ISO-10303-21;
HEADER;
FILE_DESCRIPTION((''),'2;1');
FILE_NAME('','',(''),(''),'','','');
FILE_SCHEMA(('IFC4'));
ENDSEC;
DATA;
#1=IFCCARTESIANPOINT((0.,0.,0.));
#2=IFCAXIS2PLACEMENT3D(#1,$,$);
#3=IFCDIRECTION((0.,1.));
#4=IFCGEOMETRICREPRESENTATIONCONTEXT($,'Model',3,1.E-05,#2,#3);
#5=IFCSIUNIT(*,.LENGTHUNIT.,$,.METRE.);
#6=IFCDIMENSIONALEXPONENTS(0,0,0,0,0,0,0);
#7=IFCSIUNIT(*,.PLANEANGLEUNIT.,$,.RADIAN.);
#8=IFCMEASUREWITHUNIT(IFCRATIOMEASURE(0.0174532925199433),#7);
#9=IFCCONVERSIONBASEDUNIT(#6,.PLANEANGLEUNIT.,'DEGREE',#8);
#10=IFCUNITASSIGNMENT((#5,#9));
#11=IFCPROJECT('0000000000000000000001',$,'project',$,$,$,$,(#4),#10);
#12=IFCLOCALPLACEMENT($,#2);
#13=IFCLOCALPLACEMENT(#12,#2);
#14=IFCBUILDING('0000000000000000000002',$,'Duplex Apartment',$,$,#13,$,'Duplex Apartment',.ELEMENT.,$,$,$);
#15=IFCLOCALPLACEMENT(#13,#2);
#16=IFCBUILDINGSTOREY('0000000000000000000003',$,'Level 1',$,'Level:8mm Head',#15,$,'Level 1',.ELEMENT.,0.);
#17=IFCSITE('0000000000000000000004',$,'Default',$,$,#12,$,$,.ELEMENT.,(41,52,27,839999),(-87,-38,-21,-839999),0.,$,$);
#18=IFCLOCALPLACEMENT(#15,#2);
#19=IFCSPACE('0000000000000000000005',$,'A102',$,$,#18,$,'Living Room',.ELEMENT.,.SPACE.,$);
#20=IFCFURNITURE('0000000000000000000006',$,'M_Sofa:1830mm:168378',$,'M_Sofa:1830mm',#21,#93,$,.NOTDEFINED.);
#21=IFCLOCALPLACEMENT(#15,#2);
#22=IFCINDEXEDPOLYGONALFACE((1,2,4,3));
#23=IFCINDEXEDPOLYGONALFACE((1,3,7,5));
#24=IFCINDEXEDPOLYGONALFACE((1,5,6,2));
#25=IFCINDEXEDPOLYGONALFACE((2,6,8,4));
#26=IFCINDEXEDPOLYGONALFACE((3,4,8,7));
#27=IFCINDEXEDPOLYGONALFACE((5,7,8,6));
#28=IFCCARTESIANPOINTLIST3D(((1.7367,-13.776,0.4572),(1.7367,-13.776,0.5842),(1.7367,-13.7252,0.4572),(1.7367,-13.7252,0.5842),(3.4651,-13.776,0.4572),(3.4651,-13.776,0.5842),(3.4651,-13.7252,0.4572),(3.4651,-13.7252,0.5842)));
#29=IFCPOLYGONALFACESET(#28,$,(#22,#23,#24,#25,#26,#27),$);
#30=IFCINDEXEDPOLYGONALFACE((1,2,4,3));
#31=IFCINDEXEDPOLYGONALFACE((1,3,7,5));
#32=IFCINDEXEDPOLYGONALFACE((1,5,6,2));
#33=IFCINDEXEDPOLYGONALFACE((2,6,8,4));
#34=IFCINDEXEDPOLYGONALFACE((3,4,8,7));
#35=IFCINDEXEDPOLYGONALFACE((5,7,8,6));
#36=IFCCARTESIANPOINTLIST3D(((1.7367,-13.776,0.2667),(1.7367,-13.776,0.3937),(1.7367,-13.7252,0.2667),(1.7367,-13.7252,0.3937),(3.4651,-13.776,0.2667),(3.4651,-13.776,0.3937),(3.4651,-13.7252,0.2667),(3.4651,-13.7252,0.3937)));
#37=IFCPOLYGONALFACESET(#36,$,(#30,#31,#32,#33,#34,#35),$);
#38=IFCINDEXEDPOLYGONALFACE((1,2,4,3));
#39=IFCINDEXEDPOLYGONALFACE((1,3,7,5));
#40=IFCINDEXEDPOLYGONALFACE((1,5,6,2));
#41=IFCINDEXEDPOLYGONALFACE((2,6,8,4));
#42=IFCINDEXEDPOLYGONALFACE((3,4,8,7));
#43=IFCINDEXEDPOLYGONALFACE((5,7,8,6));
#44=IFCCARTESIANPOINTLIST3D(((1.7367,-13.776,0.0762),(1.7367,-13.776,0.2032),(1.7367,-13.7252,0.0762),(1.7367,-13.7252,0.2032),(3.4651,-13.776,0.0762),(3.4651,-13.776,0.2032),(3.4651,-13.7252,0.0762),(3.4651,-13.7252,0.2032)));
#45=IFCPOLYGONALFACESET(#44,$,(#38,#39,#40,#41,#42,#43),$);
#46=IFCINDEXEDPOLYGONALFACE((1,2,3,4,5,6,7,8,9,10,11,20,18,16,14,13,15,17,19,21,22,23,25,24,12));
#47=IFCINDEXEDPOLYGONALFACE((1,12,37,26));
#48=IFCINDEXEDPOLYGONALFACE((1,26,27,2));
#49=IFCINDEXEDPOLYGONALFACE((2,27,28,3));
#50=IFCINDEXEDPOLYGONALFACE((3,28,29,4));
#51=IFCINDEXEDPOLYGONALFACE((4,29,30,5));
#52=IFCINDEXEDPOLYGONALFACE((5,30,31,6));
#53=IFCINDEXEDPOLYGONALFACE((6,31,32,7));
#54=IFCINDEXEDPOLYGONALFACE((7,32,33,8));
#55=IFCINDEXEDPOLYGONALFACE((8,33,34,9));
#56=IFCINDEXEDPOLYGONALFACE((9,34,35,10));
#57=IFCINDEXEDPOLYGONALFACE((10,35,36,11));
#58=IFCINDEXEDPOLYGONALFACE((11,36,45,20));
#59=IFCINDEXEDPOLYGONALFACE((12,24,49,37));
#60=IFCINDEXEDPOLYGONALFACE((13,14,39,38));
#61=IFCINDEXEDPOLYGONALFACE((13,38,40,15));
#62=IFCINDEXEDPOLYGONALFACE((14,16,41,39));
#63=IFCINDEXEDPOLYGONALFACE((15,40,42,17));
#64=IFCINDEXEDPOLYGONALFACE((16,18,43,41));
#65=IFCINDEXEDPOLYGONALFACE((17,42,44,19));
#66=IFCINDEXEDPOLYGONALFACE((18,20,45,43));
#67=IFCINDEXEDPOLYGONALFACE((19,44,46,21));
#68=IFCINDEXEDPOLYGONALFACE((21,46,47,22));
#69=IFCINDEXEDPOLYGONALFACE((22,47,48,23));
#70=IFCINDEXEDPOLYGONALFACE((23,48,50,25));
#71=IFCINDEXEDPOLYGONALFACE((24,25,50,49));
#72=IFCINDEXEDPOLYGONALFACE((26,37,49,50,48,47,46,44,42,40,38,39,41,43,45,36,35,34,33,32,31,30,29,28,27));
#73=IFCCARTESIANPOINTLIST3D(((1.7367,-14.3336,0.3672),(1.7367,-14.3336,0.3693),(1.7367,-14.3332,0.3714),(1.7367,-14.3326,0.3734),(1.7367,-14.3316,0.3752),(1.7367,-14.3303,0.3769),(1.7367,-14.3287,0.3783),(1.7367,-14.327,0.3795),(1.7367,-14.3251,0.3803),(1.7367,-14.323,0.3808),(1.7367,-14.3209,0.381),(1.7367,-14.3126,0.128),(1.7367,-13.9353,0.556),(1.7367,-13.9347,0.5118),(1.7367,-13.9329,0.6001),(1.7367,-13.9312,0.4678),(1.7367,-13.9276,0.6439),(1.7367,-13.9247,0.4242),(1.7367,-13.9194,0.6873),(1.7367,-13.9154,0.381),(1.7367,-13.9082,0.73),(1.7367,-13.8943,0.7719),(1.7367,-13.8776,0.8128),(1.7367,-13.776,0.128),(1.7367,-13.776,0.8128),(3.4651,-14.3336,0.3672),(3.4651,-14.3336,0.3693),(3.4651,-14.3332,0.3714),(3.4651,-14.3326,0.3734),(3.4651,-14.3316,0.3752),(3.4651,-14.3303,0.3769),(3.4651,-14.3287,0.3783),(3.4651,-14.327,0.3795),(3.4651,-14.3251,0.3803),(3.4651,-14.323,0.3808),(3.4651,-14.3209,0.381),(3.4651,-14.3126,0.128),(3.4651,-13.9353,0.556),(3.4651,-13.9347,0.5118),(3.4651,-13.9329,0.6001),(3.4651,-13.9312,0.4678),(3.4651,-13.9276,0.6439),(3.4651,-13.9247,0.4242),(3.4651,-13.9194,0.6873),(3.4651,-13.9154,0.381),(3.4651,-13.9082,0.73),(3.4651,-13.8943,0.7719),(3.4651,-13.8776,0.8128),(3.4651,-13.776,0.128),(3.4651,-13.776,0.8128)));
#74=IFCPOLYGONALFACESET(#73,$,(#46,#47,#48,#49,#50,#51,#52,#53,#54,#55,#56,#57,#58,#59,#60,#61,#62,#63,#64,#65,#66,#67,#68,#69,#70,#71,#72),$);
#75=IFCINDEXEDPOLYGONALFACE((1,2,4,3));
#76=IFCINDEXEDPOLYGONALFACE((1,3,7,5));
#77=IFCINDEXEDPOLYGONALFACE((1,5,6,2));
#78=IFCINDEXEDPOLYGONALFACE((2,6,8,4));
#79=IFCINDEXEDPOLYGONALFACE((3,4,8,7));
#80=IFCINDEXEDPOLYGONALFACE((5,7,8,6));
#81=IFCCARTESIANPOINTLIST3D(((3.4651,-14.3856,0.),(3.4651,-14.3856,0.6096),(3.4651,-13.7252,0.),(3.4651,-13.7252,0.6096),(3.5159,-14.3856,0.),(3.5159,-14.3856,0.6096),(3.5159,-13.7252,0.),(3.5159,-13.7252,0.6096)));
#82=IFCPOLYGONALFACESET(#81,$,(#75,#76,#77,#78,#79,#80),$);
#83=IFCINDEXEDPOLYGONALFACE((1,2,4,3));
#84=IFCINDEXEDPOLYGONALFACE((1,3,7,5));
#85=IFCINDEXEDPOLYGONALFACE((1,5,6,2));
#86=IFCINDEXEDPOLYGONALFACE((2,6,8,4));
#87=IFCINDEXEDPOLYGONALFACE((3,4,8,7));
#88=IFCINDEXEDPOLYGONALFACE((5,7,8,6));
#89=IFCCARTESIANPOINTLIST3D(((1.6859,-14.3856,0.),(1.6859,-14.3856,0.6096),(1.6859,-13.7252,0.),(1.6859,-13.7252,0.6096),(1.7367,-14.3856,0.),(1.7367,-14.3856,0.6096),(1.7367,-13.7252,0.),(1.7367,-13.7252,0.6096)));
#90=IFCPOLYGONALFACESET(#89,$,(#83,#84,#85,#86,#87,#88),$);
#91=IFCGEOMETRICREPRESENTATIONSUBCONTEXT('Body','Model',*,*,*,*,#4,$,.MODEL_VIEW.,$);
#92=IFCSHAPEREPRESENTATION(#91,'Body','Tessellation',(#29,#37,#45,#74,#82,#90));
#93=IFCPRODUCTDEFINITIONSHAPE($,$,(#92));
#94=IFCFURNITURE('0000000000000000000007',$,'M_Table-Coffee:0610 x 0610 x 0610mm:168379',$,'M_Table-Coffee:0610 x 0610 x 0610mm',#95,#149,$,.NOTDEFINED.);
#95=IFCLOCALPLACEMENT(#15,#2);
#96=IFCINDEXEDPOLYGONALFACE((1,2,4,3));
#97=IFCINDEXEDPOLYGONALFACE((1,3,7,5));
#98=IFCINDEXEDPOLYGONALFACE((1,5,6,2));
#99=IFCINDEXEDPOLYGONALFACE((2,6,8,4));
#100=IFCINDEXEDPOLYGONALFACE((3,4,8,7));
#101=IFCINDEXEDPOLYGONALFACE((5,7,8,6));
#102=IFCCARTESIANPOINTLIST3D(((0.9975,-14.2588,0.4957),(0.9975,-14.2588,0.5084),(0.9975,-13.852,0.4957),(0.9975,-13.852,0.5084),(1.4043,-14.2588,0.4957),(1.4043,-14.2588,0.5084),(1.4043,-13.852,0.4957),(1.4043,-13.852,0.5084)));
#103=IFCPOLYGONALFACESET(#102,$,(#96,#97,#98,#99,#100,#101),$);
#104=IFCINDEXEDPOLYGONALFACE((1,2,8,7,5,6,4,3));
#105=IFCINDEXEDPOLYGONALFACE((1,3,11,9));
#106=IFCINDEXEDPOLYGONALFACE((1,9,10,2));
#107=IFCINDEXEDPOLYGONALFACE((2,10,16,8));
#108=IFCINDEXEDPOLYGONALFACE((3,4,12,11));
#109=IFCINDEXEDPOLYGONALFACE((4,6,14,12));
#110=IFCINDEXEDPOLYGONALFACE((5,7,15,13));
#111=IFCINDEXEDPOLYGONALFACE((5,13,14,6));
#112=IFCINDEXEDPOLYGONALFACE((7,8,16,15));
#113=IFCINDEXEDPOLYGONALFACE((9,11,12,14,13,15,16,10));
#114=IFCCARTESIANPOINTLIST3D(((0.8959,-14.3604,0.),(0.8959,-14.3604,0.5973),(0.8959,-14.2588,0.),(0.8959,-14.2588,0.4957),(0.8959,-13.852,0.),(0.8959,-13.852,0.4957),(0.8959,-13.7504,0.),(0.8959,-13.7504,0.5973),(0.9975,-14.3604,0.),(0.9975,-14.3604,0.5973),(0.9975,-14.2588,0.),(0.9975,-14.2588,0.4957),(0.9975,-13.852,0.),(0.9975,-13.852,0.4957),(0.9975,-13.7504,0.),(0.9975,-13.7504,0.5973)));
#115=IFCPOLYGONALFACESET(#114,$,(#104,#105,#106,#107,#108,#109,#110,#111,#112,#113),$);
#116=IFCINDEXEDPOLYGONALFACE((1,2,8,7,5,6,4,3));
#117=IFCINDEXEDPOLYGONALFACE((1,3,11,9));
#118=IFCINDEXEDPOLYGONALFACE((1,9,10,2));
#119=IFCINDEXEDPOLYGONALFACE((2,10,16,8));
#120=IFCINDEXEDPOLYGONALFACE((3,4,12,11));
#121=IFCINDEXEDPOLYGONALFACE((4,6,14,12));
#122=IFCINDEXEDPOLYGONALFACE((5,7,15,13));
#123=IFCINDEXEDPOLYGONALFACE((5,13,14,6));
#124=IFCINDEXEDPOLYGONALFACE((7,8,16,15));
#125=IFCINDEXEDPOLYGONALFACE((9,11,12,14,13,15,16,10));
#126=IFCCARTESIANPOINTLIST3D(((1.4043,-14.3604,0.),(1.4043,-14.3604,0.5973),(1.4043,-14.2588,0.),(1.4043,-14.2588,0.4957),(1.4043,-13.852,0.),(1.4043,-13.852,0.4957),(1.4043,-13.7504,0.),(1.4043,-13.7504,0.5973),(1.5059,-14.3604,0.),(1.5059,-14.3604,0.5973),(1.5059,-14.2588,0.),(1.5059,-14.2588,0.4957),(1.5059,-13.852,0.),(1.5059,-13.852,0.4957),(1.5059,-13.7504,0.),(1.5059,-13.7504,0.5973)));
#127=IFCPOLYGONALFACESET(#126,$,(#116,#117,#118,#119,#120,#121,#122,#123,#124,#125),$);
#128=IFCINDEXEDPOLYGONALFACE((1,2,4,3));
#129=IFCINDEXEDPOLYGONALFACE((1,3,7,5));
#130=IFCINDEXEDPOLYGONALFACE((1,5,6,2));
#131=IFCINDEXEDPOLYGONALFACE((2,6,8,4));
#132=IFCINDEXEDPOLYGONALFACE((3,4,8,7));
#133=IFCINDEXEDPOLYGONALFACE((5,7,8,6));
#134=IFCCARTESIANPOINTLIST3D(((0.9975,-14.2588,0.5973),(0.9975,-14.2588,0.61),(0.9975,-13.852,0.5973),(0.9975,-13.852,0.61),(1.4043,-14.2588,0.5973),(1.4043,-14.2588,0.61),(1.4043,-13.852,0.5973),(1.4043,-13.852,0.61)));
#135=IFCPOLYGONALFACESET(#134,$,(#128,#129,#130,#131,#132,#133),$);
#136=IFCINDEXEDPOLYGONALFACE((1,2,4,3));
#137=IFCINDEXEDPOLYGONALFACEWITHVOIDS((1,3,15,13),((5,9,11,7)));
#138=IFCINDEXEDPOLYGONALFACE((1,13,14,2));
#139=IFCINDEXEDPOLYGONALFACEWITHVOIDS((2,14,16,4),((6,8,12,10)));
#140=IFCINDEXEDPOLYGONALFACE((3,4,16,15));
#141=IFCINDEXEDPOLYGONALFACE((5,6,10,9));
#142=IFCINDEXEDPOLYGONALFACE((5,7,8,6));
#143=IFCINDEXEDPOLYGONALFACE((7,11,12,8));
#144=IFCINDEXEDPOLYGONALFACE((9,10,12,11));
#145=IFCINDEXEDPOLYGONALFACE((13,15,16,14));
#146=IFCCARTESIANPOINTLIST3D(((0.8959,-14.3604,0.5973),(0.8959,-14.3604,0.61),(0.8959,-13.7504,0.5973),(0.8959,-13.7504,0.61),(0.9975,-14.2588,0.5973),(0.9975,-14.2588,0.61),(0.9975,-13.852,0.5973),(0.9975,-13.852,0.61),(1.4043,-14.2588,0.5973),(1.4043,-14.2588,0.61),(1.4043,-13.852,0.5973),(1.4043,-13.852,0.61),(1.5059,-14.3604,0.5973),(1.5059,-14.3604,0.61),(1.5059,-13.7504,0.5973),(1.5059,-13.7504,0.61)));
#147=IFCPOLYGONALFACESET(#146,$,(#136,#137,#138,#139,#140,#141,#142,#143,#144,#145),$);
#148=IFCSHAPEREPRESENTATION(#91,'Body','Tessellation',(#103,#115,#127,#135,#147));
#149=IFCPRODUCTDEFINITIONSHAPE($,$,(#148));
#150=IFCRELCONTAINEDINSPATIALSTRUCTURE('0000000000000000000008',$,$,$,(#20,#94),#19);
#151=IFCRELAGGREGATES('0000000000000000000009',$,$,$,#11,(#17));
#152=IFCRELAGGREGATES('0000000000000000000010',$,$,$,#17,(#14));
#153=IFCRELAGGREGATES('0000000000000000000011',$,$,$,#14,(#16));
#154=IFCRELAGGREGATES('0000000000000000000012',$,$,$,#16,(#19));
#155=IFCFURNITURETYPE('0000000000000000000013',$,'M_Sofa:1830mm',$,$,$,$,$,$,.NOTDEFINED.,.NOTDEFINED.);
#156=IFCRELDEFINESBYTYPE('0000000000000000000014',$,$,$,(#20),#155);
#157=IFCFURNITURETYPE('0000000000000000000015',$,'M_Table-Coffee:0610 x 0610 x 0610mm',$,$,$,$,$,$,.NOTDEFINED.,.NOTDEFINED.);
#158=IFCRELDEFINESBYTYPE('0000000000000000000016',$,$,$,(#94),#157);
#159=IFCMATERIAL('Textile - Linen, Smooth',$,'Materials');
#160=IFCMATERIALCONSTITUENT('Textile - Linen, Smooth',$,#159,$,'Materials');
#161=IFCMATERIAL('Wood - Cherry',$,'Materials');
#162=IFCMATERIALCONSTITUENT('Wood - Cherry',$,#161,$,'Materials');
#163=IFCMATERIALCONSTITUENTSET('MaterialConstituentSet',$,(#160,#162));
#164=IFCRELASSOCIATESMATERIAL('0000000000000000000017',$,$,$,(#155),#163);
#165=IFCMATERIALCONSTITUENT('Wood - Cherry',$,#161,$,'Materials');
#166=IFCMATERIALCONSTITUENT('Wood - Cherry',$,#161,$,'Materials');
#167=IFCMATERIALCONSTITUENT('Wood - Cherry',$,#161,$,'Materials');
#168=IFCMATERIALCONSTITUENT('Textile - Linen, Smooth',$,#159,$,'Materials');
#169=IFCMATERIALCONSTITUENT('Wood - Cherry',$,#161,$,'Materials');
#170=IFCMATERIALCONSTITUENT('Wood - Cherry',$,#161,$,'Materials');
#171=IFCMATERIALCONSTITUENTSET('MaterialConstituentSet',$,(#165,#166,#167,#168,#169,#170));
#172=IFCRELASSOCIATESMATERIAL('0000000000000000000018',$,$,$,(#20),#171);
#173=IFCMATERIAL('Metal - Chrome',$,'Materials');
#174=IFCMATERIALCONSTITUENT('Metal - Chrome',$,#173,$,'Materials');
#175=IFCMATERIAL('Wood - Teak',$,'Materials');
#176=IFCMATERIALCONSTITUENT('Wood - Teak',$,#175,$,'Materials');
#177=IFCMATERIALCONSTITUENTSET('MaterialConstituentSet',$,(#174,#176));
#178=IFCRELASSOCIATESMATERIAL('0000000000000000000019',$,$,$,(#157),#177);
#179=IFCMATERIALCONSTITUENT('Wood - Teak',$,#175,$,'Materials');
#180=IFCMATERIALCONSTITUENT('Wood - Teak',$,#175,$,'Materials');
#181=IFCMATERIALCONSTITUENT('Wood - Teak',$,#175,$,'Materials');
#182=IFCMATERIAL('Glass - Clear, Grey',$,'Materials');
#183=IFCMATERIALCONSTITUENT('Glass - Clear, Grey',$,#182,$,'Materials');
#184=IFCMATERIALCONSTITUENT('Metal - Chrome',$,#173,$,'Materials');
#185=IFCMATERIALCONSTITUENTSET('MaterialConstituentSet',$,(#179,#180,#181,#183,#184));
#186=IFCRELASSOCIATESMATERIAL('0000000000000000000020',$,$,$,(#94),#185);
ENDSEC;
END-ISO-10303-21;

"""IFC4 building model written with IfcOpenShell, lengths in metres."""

from ifc_helpers import new_model, entity, si_unit, converted_unit, direction, frame, origin, place, context, subcontext, project, spatial, indexed_curve, outline, extrude, source, transform, mapped, material, constituent, constituent_set, type_object, type_shapes, element, save


model = new_model("IFC4")

# Units and contexts
model_context = context("Model", 3, precision=1e-05, world=origin(), true_north=direction((0.0, 1.0)))
body_context = subcontext(model_context, "Body", "Model", "MODEL_VIEW")
ifc_project = project(units=[si_unit("LENGTHUNIT", "METRE"), converted_unit("PLANEANGLEUNIT", "DEGREE", entity("IfcRatioMeasure", 0.0174532925199433), si_unit("PLANEANGLEUNIT", "RADIAN"), dimensions=[0, 0, 0, 0, 0, 0, 0])], contexts=[model_context])

# Site, building, storey
site_placement = place(None, origin())
site = spatial("IfcSite", under=ifc_project, at=site_placement, Name="Default", CompositionType="ELEMENT", RefLatitude=(41, 52, 27, 839999), RefLongitude=(-87, -38, -21, -839999), RefElevation=0.0)
building_placement = place(site_placement, origin())
building = spatial("IfcBuilding", under=site, at=building_placement, Name="Duplex Apartment", LongName="Duplex Apartment", CompositionType="ELEMENT")
storey_placement = place(building_placement, origin())
storey = spatial("IfcBuildingStorey", under=building, at=storey_placement, Name="Level 1", ObjectType="Level:8mm Head", LongName="Level 1", CompositionType="ELEMENT", Elevation=0.0)

# Shared definitions
space_1_placement = place(storey_placement, origin())
space_1 = spatial("IfcSpace", under=storey, at=space_1_placement, Name="A102", LongName="Living Room", CompositionType="ELEMENT", PredefinedType="SPACE")

# Furniture
ifc_material_1 = material(Name="Wood - Cherry", Category="Materials")
ifc_material_2 = material(Name="Textile - Linen, Smooth", Category="Materials")
ifc_constituent_1 = constituent(ifc_material_2, Name="Textile - Linen, Smooth", Category="Materials")
ifc_constituent_2 = constituent(ifc_material_1, Name="Wood - Cherry", Category="Materials")
ifc_constituent_set_1 = constituent_set(constituents=[ifc_constituent_1, ifc_constituent_2], Name="MaterialConstituentSet")
furniture_type_1 = type_object("IfcFurnitureType", Name="M_Sofa:1830mm", AssemblyPlace="NOTDEFINED", PredefinedType="NOTDEFINED", material=ifc_constituent_set_1)
shared_shape_1 = source(origin(), body_context, "Body", "SweptSolid", [
    extrude(outline(indexed_curve([(-0.8642, -0.0254), (0.8642, -0.0254), (0.8642, 0.0254), (-0.8642, 0.0254), (-0.8642, -0.0254)], self_intersect=False)), frame((0.0704, 0.451, 0.4572)), (0.0, 0.0, 1.0), 0.127),
    extrude(outline(indexed_curve([(-0.8642, -0.0254), (0.8642, -0.0254), (0.8642, 0.0254), (-0.8642, 0.0254), (-0.8642, -0.0254)], self_intersect=False)), frame((0.0704, 0.451, 0.2667)), (0.0, 0.0, 1.0), 0.127),
    extrude(outline(indexed_curve([(-0.8642, -0.0254), (0.8642, -0.0254), (0.8642, 0.0254), (-0.8642, 0.0254), (-0.8642, -0.0254)], self_intersect=False)), frame((0.0704, 0.451, 0.0762)), (0.0, 0.0, 1.0), 0.127),
    extrude(outline(indexed_curve([(-0.1292, 0.0491), (0.2763, 0.0491), (0.2784, 0.0493), (0.2805, 0.0498), (0.2824, 0.0506), (0.2842, 0.0518), (0.2857, 0.0532), (0.287, 0.0549), (0.288, 0.0567), (0.2887, 0.0587), (0.289, 0.0608), (0.289, 0.0629), (0.2681, 0.3021), (-0.2686, 0.3021), (-0.2686, -0.3827), (-0.167, -0.3827), (-0.1503, -0.3418), (-0.1363, -0.2999), (-0.1252, -0.2572), (-0.117, -0.2138), (-0.1117, -0.17), (-0.1093, -0.1259), (-0.1099, -0.0817), (-0.1134, -0.0377), (-0.1199, 0.006), (-0.1292, 0.0491)], self_intersect=False)), frame((-0.7938, 0.157, 0.4301), z_axis=(1.0, 0.0, 0.0), x_axis=(0.0, -1.0, 0.0)), (0.0, 0.0, 1.0), 1.7284),
    extrude(outline(indexed_curve([(-0.0254, -0.3302), (0.0254, -0.3302), (0.0254, 0.3302), (-0.0254, 0.3302), (-0.0254, -0.3302)], self_intersect=False)), frame((0.96, 0.1462, 0.0), z_axis=(0.0, 0.0, 1.0), x_axis=(-1.0, 0.0, 0.0)), (0.0, 0.0, 1.0), 0.6096),
    extrude(outline(indexed_curve([(-0.0254, -0.3302), (0.0254, -0.3302), (0.0254, 0.3302), (-0.0254, 0.3302), (-0.0254, -0.3302)], self_intersect=False)), frame((-0.8192, 0.1462, 0.0), z_axis=(0.0, 0.0, 1.0), x_axis=(-1.0, 0.0, 0.0)), (0.0, 0.0, 1.0), 0.6096),
])
type_shapes(furniture_type_1, [shared_shape_1])
ifc_constituent_3 = constituent(ifc_material_1, Name="Wood - Cherry", Category="Materials")
ifc_constituent_4 = constituent(ifc_material_1, Name="Wood - Cherry", Category="Materials")
ifc_constituent_5 = constituent(ifc_material_1, Name="Wood - Cherry", Category="Materials")
ifc_constituent_6 = constituent(ifc_material_2, Name="Textile - Linen, Smooth", Category="Materials")
ifc_constituent_7 = constituent(ifc_material_1, Name="Wood - Cherry", Category="Materials")
ifc_constituent_8 = constituent(ifc_material_1, Name="Wood - Cherry", Category="Materials")
ifc_constituent_set_2 = constituent_set(constituents=[ifc_constituent_3, ifc_constituent_4, ifc_constituent_5, ifc_constituent_6, ifc_constituent_7, ifc_constituent_8], Name="MaterialConstituentSet")
furniture_1_placement = place(space_1_placement, frame((2.5305, -14.2015, 0.0)))
element("IfcFurniture", 1, at=furniture_1_placement, inside=space_1, type_object=furniture_type_1, material=ifc_constituent_set_2, Name="M_Sofa:1830mm:168378", ObjectType="M_Sofa:1830mm", PredefinedType="NOTDEFINED", context=body_context, shape_type="MappedRepresentation", body=[
    mapped(shared_shape_1, transform((0.0, 0.0, 0.0), scale=1.0)),
])
ifc_material_3 = material(Name="Wood - Teak", Category="Materials")
ifc_constituent_9 = constituent(ifc_material_3, Name="Wood - Teak", Category="Materials")
ifc_constituent_10 = constituent(ifc_material_3, Name="Wood - Teak", Category="Materials")
ifc_constituent_11 = constituent(ifc_material_3, Name="Wood - Teak", Category="Materials")
ifc_material_4 = material(Name="Glass - Clear, Grey", Category="Materials")
ifc_constituent_12 = constituent(ifc_material_4, Name="Glass - Clear, Grey", Category="Materials")
ifc_material_5 = material(Name="Metal - Chrome", Category="Materials")
ifc_constituent_13 = constituent(ifc_material_5, Name="Metal - Chrome", Category="Materials")
ifc_constituent_set_3 = constituent_set(constituents=[ifc_constituent_9, ifc_constituent_10, ifc_constituent_11, ifc_constituent_12, ifc_constituent_13], Name="MaterialConstituentSet")
ifc_constituent_14 = constituent(ifc_material_5, Name="Metal - Chrome", Category="Materials")
ifc_constituent_15 = constituent(ifc_material_3, Name="Wood - Teak", Category="Materials")
ifc_constituent_set_4 = constituent_set(constituents=[ifc_constituent_14, ifc_constituent_15], Name="MaterialConstituentSet")
furniture_type_2 = type_object("IfcFurnitureType", Name="M_Table-Coffee:0610 x 0610 x 0610mm", AssemblyPlace="NOTDEFINED", PredefinedType="NOTDEFINED", material=ifc_constituent_set_4)
shared_shape_2 = source(origin(), body_context, "Body", "SweptSolid", [
    extrude(outline(indexed_curve([(-0.2034, -0.2034), (0.2034, -0.2034), (0.2034, 0.2034), (-0.2034, 0.2034), (-0.2034, -0.2034)], self_intersect=False)), frame((0.0183, 0.0952, 0.4957), z_axis=(0.0, 0.0, 1.0), x_axis=(-1.0, 0.0, 0.0)), (0.0, 0.0, 1.0), 0.0127),
    extrude(outline(indexed_curve([(-0.2732, -0.305), (0.324, -0.305), (0.324, 0.305), (-0.2732, 0.305), (-0.2732, 0.2034), (0.2225, 0.2034), (0.2225, -0.2034), (-0.2732, -0.2034), (-0.2732, -0.305)], self_intersect=False)), frame((0.2217, 0.0952, 0.2732), z_axis=(1.0, 0.0, 0.0), x_axis=(0.0, 0.0, 1.0)), (0.0, 0.0, 1.0), 0.1016),
    extrude(outline(indexed_curve([(-0.305, -0.3241), (0.305, -0.3241), (0.305, 0.2733), (0.2034, 0.2733), (0.2034, -0.2224), (-0.2034, -0.2224), (-0.2034, 0.2733), (-0.305, 0.2733), (-0.305, -0.3241)], self_intersect=False)), frame((-0.2867, 0.0952, 0.2733), z_axis=(1.0, 0.0, 0.0), x_axis=(0.0, -1.0, 0.0)), (0.0, 0.0, 1.0), 0.1016),
    extrude(outline(indexed_curve([(-0.2034, -0.2034), (0.2034, -0.2034), (0.2034, 0.2034), (-0.2034, 0.2034), (-0.2034, -0.2034)], self_intersect=False)), frame((0.0183, 0.0952, 0.5973), z_axis=(0.0, 0.0, 1.0), x_axis=(-1.0, 0.0, 0.0)), (0.0, 0.0, 1.0), 0.0127),
    extrude(outline(indexed_curve([(-0.305, -0.305), (0.305, -0.305), (0.305, 0.305), (-0.305, 0.305), (-0.305, -0.305)], self_intersect=False), holes=[indexed_curve([(-0.2034, -0.2034), (-0.2034, 0.2034), (0.2034, 0.2034), (0.2034, -0.2034), (-0.2034, -0.2034)], self_intersect=False)]), frame((0.0183, 0.0952, 0.5973), z_axis=(0.0, 0.0, 1.0), x_axis=(-1.0, 0.0, 0.0)), (0.0, 0.0, 1.0), 0.0127),
])
type_shapes(furniture_type_2, [shared_shape_2])
furniture_2_placement = place(space_1_placement, frame((1.2192, -13.9602, 0.0), z_axis=(0.0, 0.0, 1.0), x_axis=(-1.0, 0.0, 0.0)))
element("IfcFurniture", 2, at=furniture_2_placement, inside=space_1, type_object=furniture_type_2, material=ifc_constituent_set_3, Name="M_Table-Coffee:0610 x 0610 x 0610mm:168379", ObjectType="M_Table-Coffee:0610 x 0610 x 0610mm", PredefinedType="NOTDEFINED", context=body_context, shape_type="MappedRepresentation", body=[
    mapped(shared_shape_2, transform((0.0, 0.0, 0.0), scale=1.0)),
])

save(model, "model.ifc")
